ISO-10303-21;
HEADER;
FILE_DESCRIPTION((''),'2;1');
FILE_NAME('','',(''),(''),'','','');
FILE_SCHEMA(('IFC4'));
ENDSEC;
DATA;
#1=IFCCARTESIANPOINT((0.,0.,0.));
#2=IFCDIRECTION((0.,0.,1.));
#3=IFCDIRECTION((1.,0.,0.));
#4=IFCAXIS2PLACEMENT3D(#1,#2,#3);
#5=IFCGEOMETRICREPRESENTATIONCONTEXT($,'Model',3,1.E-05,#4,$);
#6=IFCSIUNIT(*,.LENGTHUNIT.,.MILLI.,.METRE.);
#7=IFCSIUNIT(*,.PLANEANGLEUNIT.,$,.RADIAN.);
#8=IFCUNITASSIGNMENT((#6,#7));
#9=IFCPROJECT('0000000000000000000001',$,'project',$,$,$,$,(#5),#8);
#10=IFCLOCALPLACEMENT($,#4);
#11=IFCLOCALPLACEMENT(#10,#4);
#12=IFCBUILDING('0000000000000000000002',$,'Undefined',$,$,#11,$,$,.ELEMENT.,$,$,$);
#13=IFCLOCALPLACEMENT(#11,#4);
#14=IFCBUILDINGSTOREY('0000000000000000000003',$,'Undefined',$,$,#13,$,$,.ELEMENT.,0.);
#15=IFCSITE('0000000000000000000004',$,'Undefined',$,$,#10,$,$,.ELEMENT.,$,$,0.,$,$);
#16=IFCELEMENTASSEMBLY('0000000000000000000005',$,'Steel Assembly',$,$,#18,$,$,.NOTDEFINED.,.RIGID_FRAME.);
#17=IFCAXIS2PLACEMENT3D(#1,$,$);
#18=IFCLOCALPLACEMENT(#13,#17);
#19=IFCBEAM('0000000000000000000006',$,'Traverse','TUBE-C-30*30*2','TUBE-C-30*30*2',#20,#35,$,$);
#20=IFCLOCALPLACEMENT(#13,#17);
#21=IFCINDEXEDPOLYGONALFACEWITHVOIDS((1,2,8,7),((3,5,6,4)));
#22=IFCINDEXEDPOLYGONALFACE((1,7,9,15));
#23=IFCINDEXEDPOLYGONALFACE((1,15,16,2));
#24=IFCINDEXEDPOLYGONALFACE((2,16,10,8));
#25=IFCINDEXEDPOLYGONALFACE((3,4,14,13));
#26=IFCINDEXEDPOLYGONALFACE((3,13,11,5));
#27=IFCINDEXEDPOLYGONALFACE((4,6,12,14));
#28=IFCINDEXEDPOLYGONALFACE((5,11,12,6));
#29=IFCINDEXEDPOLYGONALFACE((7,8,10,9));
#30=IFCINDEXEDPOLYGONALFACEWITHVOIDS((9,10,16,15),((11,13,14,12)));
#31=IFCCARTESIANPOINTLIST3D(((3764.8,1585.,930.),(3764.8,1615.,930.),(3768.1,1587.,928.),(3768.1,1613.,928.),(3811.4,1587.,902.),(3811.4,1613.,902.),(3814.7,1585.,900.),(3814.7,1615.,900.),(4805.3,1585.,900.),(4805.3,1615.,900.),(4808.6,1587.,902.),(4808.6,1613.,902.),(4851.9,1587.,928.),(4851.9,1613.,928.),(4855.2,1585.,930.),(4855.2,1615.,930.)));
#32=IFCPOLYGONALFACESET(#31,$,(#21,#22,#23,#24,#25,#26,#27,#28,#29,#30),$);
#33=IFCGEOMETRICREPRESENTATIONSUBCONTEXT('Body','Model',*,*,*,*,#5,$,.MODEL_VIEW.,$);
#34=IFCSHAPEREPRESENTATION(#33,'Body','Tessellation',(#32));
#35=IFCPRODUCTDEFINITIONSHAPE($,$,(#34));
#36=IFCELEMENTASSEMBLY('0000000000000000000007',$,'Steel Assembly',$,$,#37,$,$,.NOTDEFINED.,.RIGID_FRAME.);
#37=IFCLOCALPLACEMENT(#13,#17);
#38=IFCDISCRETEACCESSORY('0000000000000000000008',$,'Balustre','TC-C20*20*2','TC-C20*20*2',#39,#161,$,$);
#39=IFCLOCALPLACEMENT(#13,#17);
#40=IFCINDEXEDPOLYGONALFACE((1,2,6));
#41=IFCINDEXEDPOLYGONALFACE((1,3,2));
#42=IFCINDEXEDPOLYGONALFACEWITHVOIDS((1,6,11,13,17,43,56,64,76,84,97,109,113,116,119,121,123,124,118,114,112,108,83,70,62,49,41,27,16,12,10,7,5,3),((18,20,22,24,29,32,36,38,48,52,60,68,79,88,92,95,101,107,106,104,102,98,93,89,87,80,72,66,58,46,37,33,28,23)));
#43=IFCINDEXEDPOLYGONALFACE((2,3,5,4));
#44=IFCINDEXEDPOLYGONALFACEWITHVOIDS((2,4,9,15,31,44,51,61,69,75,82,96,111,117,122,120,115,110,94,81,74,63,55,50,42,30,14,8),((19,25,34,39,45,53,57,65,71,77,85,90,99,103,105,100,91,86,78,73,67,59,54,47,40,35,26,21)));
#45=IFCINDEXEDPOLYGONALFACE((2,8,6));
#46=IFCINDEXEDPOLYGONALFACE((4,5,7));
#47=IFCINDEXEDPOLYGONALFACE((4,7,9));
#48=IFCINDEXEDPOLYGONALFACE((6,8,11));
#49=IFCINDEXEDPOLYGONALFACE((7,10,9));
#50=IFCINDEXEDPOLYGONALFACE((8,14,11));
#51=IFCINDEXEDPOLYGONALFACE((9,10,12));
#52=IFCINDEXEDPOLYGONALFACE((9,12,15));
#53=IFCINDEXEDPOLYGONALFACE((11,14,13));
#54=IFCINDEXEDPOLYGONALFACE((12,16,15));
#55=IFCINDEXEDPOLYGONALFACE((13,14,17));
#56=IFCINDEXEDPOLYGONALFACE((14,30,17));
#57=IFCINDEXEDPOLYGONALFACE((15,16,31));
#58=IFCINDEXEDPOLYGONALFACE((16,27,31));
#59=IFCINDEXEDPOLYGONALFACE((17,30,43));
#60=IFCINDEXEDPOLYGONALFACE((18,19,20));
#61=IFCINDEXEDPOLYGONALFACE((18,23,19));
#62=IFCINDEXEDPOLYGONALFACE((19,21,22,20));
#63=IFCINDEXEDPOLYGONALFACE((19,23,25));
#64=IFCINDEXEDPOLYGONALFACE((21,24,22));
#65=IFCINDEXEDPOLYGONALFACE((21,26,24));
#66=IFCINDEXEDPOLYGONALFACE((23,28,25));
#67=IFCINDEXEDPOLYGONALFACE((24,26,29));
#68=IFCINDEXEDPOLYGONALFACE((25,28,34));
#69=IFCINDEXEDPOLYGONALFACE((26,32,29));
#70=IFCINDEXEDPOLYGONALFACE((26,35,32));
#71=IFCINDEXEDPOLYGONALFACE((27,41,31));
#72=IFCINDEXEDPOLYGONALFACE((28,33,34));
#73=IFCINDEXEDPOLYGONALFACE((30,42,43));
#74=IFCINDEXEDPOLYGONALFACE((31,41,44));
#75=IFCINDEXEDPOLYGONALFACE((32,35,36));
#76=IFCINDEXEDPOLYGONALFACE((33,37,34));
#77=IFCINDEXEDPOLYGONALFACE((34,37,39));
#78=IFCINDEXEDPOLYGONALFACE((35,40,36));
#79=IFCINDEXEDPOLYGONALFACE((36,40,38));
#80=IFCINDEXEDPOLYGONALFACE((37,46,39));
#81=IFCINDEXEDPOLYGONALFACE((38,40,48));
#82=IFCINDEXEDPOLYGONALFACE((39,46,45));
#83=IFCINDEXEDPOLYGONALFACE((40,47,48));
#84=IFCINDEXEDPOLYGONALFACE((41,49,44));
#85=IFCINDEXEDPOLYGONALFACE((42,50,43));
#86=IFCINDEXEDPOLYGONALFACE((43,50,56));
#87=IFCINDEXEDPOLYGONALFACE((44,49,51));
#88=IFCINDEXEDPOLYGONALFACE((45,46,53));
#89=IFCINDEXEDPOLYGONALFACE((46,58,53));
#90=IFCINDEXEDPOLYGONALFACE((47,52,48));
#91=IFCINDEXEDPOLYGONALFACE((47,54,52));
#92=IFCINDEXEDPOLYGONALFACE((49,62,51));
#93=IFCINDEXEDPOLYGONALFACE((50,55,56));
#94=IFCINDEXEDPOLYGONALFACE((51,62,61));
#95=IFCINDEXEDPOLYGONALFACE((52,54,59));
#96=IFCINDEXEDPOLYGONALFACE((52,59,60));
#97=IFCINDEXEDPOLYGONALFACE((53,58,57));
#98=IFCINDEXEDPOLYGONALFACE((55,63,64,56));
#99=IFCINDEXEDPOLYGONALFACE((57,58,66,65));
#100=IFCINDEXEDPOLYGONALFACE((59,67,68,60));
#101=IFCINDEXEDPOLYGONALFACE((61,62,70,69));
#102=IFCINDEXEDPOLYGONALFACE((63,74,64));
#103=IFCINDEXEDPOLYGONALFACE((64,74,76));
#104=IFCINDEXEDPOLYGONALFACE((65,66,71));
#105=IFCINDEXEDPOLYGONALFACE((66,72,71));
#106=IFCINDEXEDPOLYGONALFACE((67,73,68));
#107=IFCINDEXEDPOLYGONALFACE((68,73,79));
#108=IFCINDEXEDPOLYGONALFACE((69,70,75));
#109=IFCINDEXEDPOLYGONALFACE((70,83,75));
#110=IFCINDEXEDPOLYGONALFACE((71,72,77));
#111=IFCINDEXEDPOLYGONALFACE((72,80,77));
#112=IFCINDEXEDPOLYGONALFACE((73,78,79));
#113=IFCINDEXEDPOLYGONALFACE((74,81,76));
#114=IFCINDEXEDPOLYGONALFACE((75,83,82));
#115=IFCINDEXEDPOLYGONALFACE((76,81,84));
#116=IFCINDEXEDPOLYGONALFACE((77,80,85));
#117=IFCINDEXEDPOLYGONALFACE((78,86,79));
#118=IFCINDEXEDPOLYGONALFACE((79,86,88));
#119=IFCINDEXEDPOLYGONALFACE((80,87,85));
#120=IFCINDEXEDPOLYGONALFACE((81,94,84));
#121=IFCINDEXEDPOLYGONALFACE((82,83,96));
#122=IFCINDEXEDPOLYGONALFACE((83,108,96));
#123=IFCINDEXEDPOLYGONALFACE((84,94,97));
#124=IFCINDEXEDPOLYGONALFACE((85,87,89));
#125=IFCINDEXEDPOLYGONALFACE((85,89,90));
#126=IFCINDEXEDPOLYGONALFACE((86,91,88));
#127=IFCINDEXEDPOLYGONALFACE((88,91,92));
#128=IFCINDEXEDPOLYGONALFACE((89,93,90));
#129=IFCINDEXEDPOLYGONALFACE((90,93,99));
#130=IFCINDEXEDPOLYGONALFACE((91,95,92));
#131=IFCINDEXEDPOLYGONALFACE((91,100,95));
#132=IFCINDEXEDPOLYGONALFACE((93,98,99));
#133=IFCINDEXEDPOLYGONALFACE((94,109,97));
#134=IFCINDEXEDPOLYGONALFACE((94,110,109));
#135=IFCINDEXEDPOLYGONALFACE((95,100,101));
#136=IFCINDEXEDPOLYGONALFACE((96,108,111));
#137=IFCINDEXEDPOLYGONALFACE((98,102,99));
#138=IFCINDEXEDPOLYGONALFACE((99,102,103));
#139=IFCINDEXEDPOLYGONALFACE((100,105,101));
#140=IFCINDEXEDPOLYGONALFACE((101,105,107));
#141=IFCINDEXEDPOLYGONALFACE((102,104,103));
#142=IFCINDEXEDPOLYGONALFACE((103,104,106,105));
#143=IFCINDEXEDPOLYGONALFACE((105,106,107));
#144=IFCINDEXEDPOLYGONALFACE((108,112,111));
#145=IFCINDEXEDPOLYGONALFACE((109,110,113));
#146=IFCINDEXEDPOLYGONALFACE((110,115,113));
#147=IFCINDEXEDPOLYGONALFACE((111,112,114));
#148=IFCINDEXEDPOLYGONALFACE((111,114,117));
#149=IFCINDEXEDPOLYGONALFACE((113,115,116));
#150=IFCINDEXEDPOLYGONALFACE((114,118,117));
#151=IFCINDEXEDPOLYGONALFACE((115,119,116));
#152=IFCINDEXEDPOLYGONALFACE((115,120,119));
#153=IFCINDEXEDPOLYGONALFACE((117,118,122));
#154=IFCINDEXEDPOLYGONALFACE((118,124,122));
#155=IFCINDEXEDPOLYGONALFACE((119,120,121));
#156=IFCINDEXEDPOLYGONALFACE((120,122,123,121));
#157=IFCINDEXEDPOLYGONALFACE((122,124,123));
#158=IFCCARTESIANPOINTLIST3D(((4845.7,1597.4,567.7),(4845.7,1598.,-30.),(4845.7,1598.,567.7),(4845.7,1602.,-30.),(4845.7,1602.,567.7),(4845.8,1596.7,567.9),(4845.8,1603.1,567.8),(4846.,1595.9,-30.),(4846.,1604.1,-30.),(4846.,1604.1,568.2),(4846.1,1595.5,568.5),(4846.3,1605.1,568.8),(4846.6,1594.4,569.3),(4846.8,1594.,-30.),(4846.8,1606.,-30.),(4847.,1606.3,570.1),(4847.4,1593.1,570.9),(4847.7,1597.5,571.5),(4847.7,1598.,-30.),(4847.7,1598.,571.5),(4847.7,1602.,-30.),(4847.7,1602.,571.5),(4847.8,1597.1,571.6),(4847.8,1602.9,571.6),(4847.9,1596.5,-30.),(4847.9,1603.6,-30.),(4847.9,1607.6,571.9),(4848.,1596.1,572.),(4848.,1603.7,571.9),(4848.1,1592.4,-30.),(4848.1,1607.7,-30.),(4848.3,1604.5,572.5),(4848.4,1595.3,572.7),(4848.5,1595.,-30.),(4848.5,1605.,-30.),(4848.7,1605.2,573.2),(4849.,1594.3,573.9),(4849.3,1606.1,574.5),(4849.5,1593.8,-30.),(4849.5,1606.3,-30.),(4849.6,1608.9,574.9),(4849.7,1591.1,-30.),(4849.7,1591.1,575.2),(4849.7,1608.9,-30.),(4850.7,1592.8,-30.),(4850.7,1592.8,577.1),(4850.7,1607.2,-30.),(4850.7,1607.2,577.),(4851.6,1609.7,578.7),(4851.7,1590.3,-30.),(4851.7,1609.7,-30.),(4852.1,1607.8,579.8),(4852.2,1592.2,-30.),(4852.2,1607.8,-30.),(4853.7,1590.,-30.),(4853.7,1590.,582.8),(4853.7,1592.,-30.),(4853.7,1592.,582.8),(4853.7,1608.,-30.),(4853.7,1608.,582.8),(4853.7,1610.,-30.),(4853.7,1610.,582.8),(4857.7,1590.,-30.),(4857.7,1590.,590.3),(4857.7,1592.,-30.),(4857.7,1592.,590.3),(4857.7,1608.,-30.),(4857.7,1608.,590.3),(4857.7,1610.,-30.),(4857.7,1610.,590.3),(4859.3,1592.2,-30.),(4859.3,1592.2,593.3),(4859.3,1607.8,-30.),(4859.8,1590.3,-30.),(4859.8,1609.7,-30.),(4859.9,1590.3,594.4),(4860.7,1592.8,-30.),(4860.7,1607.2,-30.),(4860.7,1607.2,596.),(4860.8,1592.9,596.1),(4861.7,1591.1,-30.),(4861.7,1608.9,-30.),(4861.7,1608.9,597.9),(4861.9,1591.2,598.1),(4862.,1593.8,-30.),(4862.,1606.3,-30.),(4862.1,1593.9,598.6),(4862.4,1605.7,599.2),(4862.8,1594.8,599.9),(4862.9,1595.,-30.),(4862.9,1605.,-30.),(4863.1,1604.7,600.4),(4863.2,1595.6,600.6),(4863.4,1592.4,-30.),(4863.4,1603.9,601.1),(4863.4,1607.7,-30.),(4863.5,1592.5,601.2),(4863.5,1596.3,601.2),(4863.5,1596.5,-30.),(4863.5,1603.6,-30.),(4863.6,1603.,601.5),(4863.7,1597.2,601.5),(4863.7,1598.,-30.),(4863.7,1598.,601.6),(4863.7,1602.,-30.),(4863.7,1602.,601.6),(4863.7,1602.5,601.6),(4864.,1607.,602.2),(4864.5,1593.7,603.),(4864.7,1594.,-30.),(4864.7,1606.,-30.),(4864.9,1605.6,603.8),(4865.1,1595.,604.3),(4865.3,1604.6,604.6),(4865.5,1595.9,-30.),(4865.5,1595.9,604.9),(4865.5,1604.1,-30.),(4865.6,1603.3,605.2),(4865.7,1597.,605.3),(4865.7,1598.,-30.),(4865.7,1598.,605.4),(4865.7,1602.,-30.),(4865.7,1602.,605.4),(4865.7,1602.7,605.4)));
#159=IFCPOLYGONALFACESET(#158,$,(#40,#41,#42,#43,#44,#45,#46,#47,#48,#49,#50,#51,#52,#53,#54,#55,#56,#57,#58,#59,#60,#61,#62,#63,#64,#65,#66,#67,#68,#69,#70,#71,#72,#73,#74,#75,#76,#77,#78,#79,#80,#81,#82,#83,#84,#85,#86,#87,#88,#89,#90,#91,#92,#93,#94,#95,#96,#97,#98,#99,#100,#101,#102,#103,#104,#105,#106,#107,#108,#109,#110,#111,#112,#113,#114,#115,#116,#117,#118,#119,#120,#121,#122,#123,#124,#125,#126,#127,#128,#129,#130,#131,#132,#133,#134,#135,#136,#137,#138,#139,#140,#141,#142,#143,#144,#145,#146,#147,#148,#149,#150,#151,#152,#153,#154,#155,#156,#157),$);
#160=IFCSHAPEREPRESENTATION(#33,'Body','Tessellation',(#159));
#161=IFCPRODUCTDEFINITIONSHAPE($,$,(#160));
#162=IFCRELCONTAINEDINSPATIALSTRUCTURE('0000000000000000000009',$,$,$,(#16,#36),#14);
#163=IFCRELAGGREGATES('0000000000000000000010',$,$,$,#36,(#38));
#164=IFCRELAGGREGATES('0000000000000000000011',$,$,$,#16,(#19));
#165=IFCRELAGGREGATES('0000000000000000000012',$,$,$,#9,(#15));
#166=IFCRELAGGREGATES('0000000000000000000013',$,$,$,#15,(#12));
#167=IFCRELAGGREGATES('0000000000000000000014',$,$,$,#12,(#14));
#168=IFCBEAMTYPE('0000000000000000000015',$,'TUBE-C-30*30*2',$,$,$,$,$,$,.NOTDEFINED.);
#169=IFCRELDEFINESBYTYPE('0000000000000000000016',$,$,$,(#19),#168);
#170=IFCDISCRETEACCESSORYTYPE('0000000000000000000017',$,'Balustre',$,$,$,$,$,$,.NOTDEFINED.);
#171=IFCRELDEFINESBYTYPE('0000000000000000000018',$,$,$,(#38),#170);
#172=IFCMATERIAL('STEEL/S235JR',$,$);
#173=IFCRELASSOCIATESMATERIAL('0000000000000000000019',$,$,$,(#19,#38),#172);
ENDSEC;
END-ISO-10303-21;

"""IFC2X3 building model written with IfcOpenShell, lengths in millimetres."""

from ifc_helpers import new_model, si_unit, frame, origin_with_axes, origin_2d_with_axis, place, context, subcontext, project, spatial, hollow_rectangle, extrude, clip, halfspace, material, type_object, element, aggregate, save


model = new_model("IFC2X3")

# Units and contexts
model_context = context("Model", 3, precision=1e-05, world=origin_with_axes())
body_context = subcontext(model_context, "Body", "Model", "MODEL_VIEW")
ifc_project = project(units=[si_unit("LENGTHUNIT", "METRE", prefix="MILLI"), si_unit("PLANEANGLEUNIT", "RADIAN")], contexts=[model_context])

# Site, building, storey
site_placement = place(None, origin_with_axes())
site = spatial("IfcSite", under=ifc_project, at=site_placement, Name="Undefined", CompositionType="ELEMENT", RefElevation=0.0)
building_placement = place(site_placement, origin_with_axes())
building = spatial("IfcBuilding", under=site, at=building_placement, Name="Undefined", CompositionType="ELEMENT")
storey_placement = place(building_placement, origin_with_axes())
storey = spatial("IfcBuildingStorey", under=building, at=storey_placement, Name="Undefined", CompositionType="ELEMENT", Elevation=0.0)

# Element assembly, beam
assembly_1_placement = place(storey_placement, origin_with_axes())
assembly_1 = element("IfcElementAssembly", 1, at=assembly_1_placement, inside=storey, Name="Steel Assembly", AssemblyPlace="NOTDEFINED", PredefinedType="RIGID_FRAME")
ifc_material = material(Name="STEEL/S235JR")
beam_type = type_object("IfcBeamType", Name="TUBE-C-30*30*2", PredefinedType="NOTDEFINED")
beam_placement = place(assembly_1_placement, frame((4880.6, 1600.0, 915.0), z_axis=(0.0, -1.0, 0.0), x_axis=(-1.0, 0.0, 0.0)))
beam = element("IfcBeam", 2, at=beam_placement, type_object=beam_type, material=ifc_material, Name="Traverse", Description="TUBE-C-30*30*2", ObjectType="TUBE-C-30*30*2", context=body_context, shape_type="Clipping", body=[
    clip(clip(extrude(hollow_rectangle(XDim=30.0, YDim=30.0, WallThickness=2.0, at=origin_2d_with_axis()), frame((1141.2, 0.0, 0.0), z_axis=(-1.0, 0.0, 0.0), x_axis=(0.0, -1.0, 0.0)), (0.0, 0.0, 1.0), 1141.2), halfspace(frame((1065.9, 15.0, 0.0), z_axis=(0.515548, 0.856861, 0.000003), x_axis=(0.000005, 0.0, -1.0)), False)), halfspace(frame((75.3, 15.0, 0.0), z_axis=(0.515548, -0.856861, 0.000003), x_axis=(0.000005, 0.0, -1.0)), True)),
])

# Element assembly, discrete accessory
assembly_2_placement = place(storey_placement, origin_with_axes())
assembly_2 = element("IfcElementAssembly", 3, at=assembly_2_placement, inside=storey, Name="Steel Assembly", AssemblyPlace="NOTDEFINED", PredefinedType="RIGID_FRAME")
discrete_accessory_type_1 = type_object("IfcDiscreteAccessoryType", Name="Balustre")
discrete_accessory_1_placement = place(assembly_2_placement, frame((4855.7, 1600.0, -30.0), z_axis=(0.0, 0.0, 1.0), x_axis=(1.0, 0.0, 0.0)))
discrete_accessory_1 = element("IfcDiscreteAccessory", 4, at=discrete_accessory_1_placement, type_object=discrete_accessory_type_1, material=ifc_material, Name="Balustre", Description="TC-C20*20*2", ObjectType="TC-C20*20*2", context=body_context, shape_type="Clipping", body=[
    clip(extrude(hollow_rectangle(XDim=20.0, YDim=20.0, WallThickness=2.0, InnerFilletRadius=6.0, OuterFilletRadius=8.0, at=origin_2d_with_axis()), frame((0.0, 0.0, 635.6), z_axis=(0.0, 0.0, -1.0), x_axis=(-1.0, 0.0, 0.0)), (0.0, 0.0, 1.0), 635.6), halfspace(frame((12.4, 0.0, 640.0), z_axis=(0.883506, 0.000005, -0.46842), x_axis=(-0.000005, 1.0, 0.0)), True)),
])

aggregate(assembly_2, [discrete_accessory_1])
aggregate(assembly_1, [beam])

save(model, "model.ifc")
